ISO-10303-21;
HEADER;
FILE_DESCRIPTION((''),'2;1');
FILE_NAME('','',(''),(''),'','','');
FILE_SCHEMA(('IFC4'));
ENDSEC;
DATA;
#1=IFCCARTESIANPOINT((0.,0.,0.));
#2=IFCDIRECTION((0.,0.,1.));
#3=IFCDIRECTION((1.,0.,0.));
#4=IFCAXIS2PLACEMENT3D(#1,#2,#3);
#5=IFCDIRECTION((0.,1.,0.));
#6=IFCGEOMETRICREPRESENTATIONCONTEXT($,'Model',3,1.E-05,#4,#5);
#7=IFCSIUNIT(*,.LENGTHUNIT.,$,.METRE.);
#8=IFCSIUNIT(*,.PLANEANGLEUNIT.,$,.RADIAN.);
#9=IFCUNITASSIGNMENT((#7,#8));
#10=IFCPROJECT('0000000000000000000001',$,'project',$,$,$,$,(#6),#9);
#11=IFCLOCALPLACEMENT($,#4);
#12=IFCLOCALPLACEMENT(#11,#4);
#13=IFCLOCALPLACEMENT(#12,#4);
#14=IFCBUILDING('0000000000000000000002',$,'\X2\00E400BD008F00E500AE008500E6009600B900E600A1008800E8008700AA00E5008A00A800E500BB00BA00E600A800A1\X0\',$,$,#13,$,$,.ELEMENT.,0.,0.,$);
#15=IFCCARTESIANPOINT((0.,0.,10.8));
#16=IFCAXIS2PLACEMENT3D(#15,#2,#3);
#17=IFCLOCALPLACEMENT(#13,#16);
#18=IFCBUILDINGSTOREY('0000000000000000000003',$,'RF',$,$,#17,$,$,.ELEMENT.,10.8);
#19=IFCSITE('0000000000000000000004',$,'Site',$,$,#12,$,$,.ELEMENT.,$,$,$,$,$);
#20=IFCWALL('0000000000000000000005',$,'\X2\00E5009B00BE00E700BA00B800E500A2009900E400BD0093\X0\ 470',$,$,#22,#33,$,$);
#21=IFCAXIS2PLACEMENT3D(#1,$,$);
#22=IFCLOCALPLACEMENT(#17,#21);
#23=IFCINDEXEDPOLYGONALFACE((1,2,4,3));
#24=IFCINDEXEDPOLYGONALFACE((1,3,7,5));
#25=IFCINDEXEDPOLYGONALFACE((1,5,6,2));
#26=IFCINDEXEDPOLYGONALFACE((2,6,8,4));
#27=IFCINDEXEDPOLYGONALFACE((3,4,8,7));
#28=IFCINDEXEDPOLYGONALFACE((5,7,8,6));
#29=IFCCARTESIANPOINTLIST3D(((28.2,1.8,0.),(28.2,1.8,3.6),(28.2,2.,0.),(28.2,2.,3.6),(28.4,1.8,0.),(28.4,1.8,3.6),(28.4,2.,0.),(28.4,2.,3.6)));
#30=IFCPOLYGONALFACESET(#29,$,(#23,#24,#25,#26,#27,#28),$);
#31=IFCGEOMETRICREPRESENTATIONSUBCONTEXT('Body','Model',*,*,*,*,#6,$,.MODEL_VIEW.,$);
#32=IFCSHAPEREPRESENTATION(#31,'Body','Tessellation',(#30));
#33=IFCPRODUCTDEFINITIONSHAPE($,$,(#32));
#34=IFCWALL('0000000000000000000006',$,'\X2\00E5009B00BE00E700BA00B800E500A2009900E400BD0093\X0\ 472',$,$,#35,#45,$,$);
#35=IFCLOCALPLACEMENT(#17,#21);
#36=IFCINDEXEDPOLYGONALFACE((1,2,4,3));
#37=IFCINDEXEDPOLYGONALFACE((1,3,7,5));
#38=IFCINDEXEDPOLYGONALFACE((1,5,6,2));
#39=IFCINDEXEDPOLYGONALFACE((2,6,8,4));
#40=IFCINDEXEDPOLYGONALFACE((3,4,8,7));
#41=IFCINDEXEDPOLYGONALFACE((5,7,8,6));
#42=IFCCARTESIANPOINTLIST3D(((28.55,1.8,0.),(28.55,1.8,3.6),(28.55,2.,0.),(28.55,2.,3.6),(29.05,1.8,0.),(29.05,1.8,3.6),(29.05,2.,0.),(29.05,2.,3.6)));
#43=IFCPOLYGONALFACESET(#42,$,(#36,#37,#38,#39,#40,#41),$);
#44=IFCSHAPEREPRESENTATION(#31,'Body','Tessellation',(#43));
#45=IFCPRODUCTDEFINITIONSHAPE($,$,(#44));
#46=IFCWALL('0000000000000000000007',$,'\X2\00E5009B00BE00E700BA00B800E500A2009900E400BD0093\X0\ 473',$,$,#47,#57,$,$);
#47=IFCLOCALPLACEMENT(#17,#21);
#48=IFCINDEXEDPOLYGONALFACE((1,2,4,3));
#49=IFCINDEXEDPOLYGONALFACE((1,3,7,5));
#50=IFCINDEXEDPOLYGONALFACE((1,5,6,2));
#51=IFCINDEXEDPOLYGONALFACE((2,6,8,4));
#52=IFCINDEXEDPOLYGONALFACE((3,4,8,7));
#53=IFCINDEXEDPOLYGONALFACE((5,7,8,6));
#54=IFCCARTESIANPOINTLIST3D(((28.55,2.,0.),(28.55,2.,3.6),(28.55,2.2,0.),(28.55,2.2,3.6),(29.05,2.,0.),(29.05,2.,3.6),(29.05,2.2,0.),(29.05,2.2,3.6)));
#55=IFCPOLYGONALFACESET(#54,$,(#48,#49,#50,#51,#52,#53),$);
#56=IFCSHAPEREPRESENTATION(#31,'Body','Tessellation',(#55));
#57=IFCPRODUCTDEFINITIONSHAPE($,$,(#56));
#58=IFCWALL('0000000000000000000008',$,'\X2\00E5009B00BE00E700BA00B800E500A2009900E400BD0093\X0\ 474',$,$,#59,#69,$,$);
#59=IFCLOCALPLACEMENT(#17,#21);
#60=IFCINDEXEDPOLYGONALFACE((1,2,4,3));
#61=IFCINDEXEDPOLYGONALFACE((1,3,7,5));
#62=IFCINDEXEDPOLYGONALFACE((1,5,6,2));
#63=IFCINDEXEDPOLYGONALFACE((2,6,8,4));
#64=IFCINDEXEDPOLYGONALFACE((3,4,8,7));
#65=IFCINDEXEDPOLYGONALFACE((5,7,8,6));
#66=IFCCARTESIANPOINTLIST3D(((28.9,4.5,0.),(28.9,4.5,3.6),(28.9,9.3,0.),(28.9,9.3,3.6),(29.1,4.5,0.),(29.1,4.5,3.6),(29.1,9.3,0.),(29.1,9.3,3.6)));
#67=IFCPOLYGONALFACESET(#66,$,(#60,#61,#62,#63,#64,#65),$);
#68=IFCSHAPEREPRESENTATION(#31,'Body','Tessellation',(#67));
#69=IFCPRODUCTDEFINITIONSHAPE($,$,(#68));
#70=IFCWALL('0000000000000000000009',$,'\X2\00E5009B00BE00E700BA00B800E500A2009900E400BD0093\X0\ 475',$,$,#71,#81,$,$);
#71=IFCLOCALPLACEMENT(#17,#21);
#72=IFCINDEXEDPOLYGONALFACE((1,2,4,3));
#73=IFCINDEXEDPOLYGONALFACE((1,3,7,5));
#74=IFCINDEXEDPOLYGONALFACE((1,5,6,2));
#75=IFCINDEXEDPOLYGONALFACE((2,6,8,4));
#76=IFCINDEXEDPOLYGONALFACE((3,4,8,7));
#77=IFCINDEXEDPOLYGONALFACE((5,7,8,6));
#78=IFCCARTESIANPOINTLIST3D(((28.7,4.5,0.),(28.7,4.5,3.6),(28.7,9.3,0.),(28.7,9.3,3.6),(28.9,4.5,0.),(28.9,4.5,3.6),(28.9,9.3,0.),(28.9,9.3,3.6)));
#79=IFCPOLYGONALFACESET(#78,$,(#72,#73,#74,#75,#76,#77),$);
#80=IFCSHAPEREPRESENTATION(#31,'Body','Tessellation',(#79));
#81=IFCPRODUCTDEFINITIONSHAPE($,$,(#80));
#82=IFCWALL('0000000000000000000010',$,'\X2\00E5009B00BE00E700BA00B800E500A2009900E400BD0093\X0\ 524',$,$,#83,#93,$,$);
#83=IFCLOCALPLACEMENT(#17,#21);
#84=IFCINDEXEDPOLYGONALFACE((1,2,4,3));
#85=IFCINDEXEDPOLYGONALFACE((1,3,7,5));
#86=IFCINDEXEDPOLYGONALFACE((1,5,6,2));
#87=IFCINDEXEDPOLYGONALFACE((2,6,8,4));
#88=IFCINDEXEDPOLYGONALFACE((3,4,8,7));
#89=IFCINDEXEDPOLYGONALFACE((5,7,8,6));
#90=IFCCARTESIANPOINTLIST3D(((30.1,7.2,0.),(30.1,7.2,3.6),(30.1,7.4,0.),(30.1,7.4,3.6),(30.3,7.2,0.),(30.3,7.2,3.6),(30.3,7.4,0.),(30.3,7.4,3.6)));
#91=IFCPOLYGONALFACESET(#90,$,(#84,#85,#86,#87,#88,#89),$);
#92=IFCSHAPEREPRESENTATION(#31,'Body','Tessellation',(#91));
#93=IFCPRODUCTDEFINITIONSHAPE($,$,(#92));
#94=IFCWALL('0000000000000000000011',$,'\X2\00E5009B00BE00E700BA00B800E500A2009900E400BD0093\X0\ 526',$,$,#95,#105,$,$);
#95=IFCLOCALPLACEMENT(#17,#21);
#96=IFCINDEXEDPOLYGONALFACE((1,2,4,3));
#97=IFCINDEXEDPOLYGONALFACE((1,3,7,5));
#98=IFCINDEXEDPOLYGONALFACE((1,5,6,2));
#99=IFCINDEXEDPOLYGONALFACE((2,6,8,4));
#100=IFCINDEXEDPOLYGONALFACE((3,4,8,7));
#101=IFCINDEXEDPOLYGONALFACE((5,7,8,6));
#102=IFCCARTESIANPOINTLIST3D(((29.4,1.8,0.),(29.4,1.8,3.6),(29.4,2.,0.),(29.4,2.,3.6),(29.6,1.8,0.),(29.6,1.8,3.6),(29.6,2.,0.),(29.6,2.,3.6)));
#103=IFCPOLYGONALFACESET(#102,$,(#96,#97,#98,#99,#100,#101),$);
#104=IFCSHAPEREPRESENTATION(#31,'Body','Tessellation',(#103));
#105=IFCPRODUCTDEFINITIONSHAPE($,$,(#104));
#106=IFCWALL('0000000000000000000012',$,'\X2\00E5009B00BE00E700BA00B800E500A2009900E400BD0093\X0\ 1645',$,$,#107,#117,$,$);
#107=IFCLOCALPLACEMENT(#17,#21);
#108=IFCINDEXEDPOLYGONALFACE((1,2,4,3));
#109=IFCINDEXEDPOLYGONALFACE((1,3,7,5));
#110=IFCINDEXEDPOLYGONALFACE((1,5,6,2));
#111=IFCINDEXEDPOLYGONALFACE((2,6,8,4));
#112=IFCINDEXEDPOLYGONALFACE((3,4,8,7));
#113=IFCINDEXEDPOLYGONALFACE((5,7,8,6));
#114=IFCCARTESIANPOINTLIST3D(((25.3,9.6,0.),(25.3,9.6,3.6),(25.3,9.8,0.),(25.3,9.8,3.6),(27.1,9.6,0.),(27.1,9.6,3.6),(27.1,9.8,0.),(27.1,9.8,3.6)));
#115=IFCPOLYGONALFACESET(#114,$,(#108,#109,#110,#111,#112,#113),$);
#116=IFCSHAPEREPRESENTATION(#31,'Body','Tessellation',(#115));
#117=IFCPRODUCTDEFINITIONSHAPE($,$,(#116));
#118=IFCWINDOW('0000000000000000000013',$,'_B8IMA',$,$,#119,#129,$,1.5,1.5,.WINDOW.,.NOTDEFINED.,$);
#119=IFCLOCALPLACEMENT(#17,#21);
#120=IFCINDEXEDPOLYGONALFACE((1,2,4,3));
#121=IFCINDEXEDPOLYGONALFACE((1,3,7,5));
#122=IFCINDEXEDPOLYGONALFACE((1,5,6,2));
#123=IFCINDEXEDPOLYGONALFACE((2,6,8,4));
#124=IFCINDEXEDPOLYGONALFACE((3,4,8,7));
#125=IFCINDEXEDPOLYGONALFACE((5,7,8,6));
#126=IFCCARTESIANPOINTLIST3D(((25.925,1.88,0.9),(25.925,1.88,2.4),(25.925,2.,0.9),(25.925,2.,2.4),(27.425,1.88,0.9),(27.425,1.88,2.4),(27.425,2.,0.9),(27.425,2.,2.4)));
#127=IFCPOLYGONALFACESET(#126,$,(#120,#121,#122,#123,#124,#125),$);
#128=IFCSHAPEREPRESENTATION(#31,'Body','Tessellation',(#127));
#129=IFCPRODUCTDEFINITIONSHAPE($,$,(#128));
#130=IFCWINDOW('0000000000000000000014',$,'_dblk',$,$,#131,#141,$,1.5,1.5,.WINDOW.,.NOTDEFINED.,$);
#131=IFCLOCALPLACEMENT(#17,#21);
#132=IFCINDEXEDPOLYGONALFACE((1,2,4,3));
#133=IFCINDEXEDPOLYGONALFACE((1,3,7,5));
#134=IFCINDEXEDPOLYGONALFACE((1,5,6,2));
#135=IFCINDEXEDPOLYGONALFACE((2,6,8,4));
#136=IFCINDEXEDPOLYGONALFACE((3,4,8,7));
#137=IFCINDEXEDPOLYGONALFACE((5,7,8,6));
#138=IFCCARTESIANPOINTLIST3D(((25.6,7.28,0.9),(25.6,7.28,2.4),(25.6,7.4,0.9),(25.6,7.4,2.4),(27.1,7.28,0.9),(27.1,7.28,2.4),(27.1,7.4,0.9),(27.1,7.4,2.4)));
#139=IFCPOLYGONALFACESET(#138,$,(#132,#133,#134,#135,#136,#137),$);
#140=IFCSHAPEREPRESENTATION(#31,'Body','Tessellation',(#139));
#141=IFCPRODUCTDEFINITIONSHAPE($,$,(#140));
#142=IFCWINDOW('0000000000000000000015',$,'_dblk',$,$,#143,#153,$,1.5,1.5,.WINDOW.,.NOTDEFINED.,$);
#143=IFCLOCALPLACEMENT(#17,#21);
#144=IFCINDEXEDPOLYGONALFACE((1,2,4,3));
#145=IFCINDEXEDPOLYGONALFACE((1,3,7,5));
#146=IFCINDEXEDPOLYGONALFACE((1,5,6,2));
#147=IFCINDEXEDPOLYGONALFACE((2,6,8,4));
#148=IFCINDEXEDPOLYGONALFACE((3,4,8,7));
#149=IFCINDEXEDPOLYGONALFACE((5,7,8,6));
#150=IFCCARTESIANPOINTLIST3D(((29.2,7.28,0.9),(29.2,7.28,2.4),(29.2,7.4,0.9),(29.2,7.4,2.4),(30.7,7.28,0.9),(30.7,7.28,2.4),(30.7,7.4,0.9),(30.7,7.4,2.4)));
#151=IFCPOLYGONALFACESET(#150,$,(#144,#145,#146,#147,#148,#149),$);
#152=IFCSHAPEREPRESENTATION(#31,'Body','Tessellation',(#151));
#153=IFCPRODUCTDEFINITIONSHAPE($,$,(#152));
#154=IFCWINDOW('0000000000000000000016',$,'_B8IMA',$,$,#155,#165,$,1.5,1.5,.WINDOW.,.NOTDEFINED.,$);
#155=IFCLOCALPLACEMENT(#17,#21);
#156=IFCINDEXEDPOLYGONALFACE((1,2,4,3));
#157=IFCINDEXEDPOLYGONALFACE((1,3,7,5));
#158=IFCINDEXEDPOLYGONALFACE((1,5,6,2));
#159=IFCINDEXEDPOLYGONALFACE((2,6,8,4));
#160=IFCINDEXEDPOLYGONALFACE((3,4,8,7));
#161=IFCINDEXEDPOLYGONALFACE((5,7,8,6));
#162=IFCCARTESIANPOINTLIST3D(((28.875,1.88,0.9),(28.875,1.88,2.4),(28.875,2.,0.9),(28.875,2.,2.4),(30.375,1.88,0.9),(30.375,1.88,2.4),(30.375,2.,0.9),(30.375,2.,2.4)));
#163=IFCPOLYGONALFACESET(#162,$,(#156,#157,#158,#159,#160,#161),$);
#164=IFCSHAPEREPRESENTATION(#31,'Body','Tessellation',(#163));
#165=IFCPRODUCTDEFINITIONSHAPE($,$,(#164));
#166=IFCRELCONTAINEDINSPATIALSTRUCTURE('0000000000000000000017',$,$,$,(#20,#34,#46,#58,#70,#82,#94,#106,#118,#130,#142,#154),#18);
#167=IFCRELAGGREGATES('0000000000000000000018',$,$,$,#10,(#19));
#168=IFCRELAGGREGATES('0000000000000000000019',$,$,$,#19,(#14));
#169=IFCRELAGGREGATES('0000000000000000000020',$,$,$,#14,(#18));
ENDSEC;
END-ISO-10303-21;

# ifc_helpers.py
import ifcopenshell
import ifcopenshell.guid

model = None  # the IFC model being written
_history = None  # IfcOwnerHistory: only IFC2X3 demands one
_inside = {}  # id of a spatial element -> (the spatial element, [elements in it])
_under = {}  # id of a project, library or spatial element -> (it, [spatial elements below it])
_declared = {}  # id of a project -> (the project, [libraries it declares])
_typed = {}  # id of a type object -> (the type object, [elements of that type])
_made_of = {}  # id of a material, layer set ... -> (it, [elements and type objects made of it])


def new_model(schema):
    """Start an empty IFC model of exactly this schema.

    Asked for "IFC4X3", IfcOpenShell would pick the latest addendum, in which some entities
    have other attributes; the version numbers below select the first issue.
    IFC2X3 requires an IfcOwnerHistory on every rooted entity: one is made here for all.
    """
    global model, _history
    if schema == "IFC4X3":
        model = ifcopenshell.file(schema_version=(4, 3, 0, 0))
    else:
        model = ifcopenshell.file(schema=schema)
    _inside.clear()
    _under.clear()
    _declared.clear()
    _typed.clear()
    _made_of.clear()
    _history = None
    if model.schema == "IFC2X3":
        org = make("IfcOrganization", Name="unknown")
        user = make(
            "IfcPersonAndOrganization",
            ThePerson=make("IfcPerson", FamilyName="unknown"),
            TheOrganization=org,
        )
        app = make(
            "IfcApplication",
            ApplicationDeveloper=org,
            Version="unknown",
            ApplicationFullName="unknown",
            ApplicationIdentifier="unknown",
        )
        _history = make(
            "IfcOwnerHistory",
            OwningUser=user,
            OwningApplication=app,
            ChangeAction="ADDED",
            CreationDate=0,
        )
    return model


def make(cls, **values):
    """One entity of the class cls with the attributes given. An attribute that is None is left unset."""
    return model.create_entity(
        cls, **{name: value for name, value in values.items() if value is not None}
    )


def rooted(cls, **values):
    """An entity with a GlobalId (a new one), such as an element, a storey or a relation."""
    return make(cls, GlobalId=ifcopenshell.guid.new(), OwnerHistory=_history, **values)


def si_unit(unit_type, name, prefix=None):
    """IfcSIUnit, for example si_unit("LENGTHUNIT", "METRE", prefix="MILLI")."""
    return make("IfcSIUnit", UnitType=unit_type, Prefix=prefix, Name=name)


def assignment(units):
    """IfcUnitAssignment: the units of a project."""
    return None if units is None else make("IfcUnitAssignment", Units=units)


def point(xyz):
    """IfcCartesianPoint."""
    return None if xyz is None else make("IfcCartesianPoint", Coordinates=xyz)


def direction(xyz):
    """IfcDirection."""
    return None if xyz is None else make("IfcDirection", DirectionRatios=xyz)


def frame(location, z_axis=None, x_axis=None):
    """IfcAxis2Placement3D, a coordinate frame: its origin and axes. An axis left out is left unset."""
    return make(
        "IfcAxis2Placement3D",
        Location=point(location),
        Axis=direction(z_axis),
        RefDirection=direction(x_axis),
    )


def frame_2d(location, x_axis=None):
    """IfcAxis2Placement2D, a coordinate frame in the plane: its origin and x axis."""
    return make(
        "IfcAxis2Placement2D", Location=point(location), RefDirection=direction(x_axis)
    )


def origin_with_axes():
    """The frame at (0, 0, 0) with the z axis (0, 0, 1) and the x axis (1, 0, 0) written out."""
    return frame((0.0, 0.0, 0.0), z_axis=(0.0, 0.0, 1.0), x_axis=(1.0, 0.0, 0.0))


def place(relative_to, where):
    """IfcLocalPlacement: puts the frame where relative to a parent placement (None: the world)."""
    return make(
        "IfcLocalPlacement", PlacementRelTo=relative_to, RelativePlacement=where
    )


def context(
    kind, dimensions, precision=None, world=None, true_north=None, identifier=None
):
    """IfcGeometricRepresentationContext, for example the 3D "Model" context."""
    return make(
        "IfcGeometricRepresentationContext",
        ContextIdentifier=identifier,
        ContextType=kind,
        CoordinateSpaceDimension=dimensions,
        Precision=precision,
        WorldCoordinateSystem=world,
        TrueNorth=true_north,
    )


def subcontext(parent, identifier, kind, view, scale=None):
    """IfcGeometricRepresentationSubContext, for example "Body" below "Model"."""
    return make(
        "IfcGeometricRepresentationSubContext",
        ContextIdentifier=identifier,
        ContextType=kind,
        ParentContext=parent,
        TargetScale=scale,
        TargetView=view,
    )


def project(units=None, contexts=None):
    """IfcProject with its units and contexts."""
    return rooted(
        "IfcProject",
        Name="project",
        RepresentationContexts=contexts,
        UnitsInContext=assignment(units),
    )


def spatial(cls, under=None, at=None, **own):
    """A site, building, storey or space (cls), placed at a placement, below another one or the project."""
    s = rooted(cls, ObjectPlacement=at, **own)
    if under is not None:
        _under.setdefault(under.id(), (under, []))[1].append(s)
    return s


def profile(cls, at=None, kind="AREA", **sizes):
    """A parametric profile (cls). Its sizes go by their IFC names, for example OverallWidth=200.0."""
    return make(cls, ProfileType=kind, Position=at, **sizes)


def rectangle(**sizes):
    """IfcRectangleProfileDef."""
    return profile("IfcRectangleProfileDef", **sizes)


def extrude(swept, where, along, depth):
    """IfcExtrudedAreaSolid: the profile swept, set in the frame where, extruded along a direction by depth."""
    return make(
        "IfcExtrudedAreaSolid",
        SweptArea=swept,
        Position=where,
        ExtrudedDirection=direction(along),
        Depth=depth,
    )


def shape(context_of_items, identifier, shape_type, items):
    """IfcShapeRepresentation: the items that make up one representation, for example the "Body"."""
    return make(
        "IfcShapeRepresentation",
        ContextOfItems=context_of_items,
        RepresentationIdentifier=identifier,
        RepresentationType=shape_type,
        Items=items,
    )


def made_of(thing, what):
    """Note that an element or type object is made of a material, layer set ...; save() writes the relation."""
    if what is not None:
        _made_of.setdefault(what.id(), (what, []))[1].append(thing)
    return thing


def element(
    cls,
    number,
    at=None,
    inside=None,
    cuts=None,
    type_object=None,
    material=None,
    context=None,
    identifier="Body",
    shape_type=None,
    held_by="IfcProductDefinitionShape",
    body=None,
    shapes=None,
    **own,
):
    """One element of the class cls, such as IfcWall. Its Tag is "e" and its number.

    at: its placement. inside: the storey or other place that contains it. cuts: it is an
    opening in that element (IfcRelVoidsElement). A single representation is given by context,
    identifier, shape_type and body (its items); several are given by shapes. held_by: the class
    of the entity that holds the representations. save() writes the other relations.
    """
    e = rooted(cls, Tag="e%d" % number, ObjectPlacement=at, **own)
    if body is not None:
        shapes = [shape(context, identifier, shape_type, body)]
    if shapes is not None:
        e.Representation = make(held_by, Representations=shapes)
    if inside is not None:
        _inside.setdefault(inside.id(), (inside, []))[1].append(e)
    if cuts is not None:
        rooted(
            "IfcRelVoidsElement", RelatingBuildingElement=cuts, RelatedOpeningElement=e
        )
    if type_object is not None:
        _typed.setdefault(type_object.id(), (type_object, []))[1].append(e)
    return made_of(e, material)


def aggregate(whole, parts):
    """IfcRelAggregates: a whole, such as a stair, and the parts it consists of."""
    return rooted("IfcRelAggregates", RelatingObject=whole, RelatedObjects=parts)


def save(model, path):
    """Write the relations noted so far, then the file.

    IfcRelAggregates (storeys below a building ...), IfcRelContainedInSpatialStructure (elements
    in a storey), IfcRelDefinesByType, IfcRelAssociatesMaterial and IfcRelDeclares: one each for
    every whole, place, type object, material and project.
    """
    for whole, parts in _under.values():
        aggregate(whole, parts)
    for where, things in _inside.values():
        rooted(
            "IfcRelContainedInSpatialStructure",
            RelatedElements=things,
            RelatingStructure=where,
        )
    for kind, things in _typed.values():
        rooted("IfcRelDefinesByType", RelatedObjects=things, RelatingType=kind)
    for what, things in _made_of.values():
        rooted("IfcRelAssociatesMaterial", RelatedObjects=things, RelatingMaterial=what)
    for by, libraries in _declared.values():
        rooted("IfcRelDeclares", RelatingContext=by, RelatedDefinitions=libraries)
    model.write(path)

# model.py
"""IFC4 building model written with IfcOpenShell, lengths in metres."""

from ifc_helpers import new_model, si_unit, direction, frame, frame_2d, origin_with_axes, place, context, subcontext, project, spatial, rectangle, extrude, element, save


model = new_model("IFC4")

# Units and contexts
model_context = context("Model", 3, precision=1e-05, world=origin_with_axes(), true_north=direction((0.0, 1.0, 0.0)))
body_context = subcontext(model_context, "Body", "Model", "MODEL_VIEW")
ifc_project = project(units=[si_unit("LENGTHUNIT", "METRE"), si_unit("PLANEANGLEUNIT", "RADIAN")], contexts=[model_context])

# Site, building, storey
placement = place(None, origin_with_axes())
site_placement = place(placement, origin_with_axes())
site = spatial("IfcSite", under=ifc_project, at=site_placement, Name="Site", CompositionType="ELEMENT")
building_placement = place(site_placement, origin_with_axes())
building = spatial("IfcBuilding", under=site, at=building_placement, Name="ä½\u008få®\u0085æ\u0096¹æ¡\u0088è\u0087ªå\u008a¨å»ºæ¨¡", CompositionType="ELEMENT", ElevationOfRefHeight=0.0, ElevationOfTerrain=0.0)
storey_placement = place(building_placement, frame((0.0, 0.0, 10.8), z_axis=(0.0, 0.0, 1.0), x_axis=(1.0, 0.0, 0.0)))
storey = spatial("IfcBuildingStorey", under=building, at=storey_placement, Name="RF", CompositionType="ELEMENT", Elevation=10.8)

# Walls
wall_1_placement = place(storey_placement, frame((28.3, 1.9, 0.0), z_axis=(0.0, 0.0, 1.0), x_axis=(0.0, 1.0, 0.0)))
element("IfcWall", 1, at=wall_1_placement, inside=storey, Name="å\u009b¾çº¸å¢\u0099ä½\u0093 470", context=body_context, shape_type="SweptSolid", body=[
    extrude(rectangle(XDim=0.2, YDim=0.2, at=frame_2d((0.0, 0.0), x_axis=(1.0, 0.0, 0.0))), frame((0.0, 0.0, 0.0), z_axis=(0.0, 0.0, 1.0)), (0.0, 0.0, 1.0), 3.6),
])
for number, where, z_axis, x_axis, name in (
    (2, (28.8, 1.9, 0.0), (0.0, 0.0, 1.0), (-1.0, 0.0, 0.0), "å\u009b¾çº¸å¢\u0099ä½\u0093 472"),
    (3, (28.8, 2.1, 0.0), (0.0, 0.0, 1.0), (-1.0, 0.0, 0.0), "å\u009b¾çº¸å¢\u0099ä½\u0093 473"),
):
    element("IfcWall", number, at=place(storey_placement, frame(where, z_axis=z_axis, x_axis=x_axis)), inside=storey, Name=name, context=body_context, shape_type="SweptSolid", body=[
        extrude(rectangle(XDim=0.5, YDim=0.2, at=frame_2d((0.0, 0.0), x_axis=(1.0, 0.0, 0.0))), frame((0.0, 0.0, 0.0), z_axis=(0.0, 0.0, 1.0)), (0.0, 0.0, 1.0), 3.6),
    ])
for number, where, z_axis, x_axis, name in (
    (4, (29.0, 6.9, 0.0), (0.0, 0.0, 1.0), (0.0, -1.0, 0.0), "å\u009b¾çº¸å¢\u0099ä½\u0093 474"),
    (5, (28.8, 6.9, 0.0), (0.0, 0.0, 1.0), (0.0, -1.0, 0.0), "å\u009b¾çº¸å¢\u0099ä½\u0093 475"),
):
    element("IfcWall", number, at=place(storey_placement, frame(where, z_axis=z_axis, x_axis=x_axis)), inside=storey, Name=name, context=body_context, shape_type="SweptSolid", body=[
        extrude(rectangle(XDim=4.8, YDim=0.2, at=frame_2d((0.0, 0.0), x_axis=(1.0, 0.0, 0.0))), frame((0.0, 0.0, 0.0), z_axis=(0.0, 0.0, 1.0)), (0.0, 0.0, 1.0), 3.6),
    ])
for number, where, z_axis, x_axis, name in (
    (6, (30.2, 7.3, 0.0), (0.0, 0.0, 1.0), (0.0, 1.0, 0.0), "å\u009b¾çº¸å¢\u0099ä½\u0093 524"),
    (7, (29.5, 1.9, 0.0), (0.0, 0.0, 1.0), (0.0, 1.0, 0.0), "å\u009b¾çº¸å¢\u0099ä½\u0093 526"),
):
    element("IfcWall", number, at=place(storey_placement, frame(where, z_axis=z_axis, x_axis=x_axis)), inside=storey, Name=name, context=body_context, shape_type="SweptSolid", body=[
        extrude(rectangle(XDim=0.2, YDim=0.2, at=frame_2d((0.0, 0.0), x_axis=(1.0, 0.0, 0.0))), frame((0.0, 0.0, 0.0), z_axis=(0.0, 0.0, 1.0)), (0.0, 0.0, 1.0), 3.6),
    ])
wall_2_placement = place(storey_placement, frame((26.2, 9.7, 0.0), z_axis=(0.0, 0.0, 1.0), x_axis=(1.0, 0.0, 0.0)))
element("IfcWall", 8, at=wall_2_placement, inside=storey, Name="å\u009b¾çº¸å¢\u0099ä½\u0093 1645", context=body_context, shape_type="SweptSolid", body=[
    extrude(rectangle(XDim=1.8, YDim=0.2, at=frame_2d((0.0, 0.0), x_axis=(1.0, 0.0, 0.0))), frame((0.0, 0.0, 0.0), z_axis=(0.0, 0.0, 1.0)), (0.0, 0.0, 1.0), 3.6),
])

# Windows
for number, where, z_axis, x_axis, name in (
    (9, (26.675, 1.94, 0.9), (0.0, 0.0, 1.0), (1.0, 0.0, 0.0), "_B8IMA"),
    (10, (26.35, 7.34, 0.9), (0.0, 0.0, 1.0), (1.0, 0.0, 0.0), "_dblk"),
    (11, (29.95, 7.34, 0.9), (0.0, 0.0, 1.0), (1.0, 0.0, 0.0), "_dblk"),
    (12, (29.625, 1.94, 0.9), (0.0, 0.0, 1.0), (1.0, 0.0, 0.0), "_B8IMA"),
):
    element("IfcWindow", number, at=place(storey_placement, frame(where, z_axis=z_axis, x_axis=x_axis)), inside=storey, Name=name, OverallHeight=1.5, OverallWidth=1.5, PartitioningType="NOTDEFINED", PredefinedType="WINDOW", context=body_context, shape_type="SweptSolid", body=[
        extrude(rectangle(XDim=1.5, YDim=0.12, at=frame_2d((0.0, 0.0), x_axis=(1.0, 0.0, 0.0))), frame((0.0, 0.0, 0.0), z_axis=(0.0, 0.0, 1.0)), (0.0, 0.0, 1.0), 1.5),
    ])

save(model, "model.ifc")
